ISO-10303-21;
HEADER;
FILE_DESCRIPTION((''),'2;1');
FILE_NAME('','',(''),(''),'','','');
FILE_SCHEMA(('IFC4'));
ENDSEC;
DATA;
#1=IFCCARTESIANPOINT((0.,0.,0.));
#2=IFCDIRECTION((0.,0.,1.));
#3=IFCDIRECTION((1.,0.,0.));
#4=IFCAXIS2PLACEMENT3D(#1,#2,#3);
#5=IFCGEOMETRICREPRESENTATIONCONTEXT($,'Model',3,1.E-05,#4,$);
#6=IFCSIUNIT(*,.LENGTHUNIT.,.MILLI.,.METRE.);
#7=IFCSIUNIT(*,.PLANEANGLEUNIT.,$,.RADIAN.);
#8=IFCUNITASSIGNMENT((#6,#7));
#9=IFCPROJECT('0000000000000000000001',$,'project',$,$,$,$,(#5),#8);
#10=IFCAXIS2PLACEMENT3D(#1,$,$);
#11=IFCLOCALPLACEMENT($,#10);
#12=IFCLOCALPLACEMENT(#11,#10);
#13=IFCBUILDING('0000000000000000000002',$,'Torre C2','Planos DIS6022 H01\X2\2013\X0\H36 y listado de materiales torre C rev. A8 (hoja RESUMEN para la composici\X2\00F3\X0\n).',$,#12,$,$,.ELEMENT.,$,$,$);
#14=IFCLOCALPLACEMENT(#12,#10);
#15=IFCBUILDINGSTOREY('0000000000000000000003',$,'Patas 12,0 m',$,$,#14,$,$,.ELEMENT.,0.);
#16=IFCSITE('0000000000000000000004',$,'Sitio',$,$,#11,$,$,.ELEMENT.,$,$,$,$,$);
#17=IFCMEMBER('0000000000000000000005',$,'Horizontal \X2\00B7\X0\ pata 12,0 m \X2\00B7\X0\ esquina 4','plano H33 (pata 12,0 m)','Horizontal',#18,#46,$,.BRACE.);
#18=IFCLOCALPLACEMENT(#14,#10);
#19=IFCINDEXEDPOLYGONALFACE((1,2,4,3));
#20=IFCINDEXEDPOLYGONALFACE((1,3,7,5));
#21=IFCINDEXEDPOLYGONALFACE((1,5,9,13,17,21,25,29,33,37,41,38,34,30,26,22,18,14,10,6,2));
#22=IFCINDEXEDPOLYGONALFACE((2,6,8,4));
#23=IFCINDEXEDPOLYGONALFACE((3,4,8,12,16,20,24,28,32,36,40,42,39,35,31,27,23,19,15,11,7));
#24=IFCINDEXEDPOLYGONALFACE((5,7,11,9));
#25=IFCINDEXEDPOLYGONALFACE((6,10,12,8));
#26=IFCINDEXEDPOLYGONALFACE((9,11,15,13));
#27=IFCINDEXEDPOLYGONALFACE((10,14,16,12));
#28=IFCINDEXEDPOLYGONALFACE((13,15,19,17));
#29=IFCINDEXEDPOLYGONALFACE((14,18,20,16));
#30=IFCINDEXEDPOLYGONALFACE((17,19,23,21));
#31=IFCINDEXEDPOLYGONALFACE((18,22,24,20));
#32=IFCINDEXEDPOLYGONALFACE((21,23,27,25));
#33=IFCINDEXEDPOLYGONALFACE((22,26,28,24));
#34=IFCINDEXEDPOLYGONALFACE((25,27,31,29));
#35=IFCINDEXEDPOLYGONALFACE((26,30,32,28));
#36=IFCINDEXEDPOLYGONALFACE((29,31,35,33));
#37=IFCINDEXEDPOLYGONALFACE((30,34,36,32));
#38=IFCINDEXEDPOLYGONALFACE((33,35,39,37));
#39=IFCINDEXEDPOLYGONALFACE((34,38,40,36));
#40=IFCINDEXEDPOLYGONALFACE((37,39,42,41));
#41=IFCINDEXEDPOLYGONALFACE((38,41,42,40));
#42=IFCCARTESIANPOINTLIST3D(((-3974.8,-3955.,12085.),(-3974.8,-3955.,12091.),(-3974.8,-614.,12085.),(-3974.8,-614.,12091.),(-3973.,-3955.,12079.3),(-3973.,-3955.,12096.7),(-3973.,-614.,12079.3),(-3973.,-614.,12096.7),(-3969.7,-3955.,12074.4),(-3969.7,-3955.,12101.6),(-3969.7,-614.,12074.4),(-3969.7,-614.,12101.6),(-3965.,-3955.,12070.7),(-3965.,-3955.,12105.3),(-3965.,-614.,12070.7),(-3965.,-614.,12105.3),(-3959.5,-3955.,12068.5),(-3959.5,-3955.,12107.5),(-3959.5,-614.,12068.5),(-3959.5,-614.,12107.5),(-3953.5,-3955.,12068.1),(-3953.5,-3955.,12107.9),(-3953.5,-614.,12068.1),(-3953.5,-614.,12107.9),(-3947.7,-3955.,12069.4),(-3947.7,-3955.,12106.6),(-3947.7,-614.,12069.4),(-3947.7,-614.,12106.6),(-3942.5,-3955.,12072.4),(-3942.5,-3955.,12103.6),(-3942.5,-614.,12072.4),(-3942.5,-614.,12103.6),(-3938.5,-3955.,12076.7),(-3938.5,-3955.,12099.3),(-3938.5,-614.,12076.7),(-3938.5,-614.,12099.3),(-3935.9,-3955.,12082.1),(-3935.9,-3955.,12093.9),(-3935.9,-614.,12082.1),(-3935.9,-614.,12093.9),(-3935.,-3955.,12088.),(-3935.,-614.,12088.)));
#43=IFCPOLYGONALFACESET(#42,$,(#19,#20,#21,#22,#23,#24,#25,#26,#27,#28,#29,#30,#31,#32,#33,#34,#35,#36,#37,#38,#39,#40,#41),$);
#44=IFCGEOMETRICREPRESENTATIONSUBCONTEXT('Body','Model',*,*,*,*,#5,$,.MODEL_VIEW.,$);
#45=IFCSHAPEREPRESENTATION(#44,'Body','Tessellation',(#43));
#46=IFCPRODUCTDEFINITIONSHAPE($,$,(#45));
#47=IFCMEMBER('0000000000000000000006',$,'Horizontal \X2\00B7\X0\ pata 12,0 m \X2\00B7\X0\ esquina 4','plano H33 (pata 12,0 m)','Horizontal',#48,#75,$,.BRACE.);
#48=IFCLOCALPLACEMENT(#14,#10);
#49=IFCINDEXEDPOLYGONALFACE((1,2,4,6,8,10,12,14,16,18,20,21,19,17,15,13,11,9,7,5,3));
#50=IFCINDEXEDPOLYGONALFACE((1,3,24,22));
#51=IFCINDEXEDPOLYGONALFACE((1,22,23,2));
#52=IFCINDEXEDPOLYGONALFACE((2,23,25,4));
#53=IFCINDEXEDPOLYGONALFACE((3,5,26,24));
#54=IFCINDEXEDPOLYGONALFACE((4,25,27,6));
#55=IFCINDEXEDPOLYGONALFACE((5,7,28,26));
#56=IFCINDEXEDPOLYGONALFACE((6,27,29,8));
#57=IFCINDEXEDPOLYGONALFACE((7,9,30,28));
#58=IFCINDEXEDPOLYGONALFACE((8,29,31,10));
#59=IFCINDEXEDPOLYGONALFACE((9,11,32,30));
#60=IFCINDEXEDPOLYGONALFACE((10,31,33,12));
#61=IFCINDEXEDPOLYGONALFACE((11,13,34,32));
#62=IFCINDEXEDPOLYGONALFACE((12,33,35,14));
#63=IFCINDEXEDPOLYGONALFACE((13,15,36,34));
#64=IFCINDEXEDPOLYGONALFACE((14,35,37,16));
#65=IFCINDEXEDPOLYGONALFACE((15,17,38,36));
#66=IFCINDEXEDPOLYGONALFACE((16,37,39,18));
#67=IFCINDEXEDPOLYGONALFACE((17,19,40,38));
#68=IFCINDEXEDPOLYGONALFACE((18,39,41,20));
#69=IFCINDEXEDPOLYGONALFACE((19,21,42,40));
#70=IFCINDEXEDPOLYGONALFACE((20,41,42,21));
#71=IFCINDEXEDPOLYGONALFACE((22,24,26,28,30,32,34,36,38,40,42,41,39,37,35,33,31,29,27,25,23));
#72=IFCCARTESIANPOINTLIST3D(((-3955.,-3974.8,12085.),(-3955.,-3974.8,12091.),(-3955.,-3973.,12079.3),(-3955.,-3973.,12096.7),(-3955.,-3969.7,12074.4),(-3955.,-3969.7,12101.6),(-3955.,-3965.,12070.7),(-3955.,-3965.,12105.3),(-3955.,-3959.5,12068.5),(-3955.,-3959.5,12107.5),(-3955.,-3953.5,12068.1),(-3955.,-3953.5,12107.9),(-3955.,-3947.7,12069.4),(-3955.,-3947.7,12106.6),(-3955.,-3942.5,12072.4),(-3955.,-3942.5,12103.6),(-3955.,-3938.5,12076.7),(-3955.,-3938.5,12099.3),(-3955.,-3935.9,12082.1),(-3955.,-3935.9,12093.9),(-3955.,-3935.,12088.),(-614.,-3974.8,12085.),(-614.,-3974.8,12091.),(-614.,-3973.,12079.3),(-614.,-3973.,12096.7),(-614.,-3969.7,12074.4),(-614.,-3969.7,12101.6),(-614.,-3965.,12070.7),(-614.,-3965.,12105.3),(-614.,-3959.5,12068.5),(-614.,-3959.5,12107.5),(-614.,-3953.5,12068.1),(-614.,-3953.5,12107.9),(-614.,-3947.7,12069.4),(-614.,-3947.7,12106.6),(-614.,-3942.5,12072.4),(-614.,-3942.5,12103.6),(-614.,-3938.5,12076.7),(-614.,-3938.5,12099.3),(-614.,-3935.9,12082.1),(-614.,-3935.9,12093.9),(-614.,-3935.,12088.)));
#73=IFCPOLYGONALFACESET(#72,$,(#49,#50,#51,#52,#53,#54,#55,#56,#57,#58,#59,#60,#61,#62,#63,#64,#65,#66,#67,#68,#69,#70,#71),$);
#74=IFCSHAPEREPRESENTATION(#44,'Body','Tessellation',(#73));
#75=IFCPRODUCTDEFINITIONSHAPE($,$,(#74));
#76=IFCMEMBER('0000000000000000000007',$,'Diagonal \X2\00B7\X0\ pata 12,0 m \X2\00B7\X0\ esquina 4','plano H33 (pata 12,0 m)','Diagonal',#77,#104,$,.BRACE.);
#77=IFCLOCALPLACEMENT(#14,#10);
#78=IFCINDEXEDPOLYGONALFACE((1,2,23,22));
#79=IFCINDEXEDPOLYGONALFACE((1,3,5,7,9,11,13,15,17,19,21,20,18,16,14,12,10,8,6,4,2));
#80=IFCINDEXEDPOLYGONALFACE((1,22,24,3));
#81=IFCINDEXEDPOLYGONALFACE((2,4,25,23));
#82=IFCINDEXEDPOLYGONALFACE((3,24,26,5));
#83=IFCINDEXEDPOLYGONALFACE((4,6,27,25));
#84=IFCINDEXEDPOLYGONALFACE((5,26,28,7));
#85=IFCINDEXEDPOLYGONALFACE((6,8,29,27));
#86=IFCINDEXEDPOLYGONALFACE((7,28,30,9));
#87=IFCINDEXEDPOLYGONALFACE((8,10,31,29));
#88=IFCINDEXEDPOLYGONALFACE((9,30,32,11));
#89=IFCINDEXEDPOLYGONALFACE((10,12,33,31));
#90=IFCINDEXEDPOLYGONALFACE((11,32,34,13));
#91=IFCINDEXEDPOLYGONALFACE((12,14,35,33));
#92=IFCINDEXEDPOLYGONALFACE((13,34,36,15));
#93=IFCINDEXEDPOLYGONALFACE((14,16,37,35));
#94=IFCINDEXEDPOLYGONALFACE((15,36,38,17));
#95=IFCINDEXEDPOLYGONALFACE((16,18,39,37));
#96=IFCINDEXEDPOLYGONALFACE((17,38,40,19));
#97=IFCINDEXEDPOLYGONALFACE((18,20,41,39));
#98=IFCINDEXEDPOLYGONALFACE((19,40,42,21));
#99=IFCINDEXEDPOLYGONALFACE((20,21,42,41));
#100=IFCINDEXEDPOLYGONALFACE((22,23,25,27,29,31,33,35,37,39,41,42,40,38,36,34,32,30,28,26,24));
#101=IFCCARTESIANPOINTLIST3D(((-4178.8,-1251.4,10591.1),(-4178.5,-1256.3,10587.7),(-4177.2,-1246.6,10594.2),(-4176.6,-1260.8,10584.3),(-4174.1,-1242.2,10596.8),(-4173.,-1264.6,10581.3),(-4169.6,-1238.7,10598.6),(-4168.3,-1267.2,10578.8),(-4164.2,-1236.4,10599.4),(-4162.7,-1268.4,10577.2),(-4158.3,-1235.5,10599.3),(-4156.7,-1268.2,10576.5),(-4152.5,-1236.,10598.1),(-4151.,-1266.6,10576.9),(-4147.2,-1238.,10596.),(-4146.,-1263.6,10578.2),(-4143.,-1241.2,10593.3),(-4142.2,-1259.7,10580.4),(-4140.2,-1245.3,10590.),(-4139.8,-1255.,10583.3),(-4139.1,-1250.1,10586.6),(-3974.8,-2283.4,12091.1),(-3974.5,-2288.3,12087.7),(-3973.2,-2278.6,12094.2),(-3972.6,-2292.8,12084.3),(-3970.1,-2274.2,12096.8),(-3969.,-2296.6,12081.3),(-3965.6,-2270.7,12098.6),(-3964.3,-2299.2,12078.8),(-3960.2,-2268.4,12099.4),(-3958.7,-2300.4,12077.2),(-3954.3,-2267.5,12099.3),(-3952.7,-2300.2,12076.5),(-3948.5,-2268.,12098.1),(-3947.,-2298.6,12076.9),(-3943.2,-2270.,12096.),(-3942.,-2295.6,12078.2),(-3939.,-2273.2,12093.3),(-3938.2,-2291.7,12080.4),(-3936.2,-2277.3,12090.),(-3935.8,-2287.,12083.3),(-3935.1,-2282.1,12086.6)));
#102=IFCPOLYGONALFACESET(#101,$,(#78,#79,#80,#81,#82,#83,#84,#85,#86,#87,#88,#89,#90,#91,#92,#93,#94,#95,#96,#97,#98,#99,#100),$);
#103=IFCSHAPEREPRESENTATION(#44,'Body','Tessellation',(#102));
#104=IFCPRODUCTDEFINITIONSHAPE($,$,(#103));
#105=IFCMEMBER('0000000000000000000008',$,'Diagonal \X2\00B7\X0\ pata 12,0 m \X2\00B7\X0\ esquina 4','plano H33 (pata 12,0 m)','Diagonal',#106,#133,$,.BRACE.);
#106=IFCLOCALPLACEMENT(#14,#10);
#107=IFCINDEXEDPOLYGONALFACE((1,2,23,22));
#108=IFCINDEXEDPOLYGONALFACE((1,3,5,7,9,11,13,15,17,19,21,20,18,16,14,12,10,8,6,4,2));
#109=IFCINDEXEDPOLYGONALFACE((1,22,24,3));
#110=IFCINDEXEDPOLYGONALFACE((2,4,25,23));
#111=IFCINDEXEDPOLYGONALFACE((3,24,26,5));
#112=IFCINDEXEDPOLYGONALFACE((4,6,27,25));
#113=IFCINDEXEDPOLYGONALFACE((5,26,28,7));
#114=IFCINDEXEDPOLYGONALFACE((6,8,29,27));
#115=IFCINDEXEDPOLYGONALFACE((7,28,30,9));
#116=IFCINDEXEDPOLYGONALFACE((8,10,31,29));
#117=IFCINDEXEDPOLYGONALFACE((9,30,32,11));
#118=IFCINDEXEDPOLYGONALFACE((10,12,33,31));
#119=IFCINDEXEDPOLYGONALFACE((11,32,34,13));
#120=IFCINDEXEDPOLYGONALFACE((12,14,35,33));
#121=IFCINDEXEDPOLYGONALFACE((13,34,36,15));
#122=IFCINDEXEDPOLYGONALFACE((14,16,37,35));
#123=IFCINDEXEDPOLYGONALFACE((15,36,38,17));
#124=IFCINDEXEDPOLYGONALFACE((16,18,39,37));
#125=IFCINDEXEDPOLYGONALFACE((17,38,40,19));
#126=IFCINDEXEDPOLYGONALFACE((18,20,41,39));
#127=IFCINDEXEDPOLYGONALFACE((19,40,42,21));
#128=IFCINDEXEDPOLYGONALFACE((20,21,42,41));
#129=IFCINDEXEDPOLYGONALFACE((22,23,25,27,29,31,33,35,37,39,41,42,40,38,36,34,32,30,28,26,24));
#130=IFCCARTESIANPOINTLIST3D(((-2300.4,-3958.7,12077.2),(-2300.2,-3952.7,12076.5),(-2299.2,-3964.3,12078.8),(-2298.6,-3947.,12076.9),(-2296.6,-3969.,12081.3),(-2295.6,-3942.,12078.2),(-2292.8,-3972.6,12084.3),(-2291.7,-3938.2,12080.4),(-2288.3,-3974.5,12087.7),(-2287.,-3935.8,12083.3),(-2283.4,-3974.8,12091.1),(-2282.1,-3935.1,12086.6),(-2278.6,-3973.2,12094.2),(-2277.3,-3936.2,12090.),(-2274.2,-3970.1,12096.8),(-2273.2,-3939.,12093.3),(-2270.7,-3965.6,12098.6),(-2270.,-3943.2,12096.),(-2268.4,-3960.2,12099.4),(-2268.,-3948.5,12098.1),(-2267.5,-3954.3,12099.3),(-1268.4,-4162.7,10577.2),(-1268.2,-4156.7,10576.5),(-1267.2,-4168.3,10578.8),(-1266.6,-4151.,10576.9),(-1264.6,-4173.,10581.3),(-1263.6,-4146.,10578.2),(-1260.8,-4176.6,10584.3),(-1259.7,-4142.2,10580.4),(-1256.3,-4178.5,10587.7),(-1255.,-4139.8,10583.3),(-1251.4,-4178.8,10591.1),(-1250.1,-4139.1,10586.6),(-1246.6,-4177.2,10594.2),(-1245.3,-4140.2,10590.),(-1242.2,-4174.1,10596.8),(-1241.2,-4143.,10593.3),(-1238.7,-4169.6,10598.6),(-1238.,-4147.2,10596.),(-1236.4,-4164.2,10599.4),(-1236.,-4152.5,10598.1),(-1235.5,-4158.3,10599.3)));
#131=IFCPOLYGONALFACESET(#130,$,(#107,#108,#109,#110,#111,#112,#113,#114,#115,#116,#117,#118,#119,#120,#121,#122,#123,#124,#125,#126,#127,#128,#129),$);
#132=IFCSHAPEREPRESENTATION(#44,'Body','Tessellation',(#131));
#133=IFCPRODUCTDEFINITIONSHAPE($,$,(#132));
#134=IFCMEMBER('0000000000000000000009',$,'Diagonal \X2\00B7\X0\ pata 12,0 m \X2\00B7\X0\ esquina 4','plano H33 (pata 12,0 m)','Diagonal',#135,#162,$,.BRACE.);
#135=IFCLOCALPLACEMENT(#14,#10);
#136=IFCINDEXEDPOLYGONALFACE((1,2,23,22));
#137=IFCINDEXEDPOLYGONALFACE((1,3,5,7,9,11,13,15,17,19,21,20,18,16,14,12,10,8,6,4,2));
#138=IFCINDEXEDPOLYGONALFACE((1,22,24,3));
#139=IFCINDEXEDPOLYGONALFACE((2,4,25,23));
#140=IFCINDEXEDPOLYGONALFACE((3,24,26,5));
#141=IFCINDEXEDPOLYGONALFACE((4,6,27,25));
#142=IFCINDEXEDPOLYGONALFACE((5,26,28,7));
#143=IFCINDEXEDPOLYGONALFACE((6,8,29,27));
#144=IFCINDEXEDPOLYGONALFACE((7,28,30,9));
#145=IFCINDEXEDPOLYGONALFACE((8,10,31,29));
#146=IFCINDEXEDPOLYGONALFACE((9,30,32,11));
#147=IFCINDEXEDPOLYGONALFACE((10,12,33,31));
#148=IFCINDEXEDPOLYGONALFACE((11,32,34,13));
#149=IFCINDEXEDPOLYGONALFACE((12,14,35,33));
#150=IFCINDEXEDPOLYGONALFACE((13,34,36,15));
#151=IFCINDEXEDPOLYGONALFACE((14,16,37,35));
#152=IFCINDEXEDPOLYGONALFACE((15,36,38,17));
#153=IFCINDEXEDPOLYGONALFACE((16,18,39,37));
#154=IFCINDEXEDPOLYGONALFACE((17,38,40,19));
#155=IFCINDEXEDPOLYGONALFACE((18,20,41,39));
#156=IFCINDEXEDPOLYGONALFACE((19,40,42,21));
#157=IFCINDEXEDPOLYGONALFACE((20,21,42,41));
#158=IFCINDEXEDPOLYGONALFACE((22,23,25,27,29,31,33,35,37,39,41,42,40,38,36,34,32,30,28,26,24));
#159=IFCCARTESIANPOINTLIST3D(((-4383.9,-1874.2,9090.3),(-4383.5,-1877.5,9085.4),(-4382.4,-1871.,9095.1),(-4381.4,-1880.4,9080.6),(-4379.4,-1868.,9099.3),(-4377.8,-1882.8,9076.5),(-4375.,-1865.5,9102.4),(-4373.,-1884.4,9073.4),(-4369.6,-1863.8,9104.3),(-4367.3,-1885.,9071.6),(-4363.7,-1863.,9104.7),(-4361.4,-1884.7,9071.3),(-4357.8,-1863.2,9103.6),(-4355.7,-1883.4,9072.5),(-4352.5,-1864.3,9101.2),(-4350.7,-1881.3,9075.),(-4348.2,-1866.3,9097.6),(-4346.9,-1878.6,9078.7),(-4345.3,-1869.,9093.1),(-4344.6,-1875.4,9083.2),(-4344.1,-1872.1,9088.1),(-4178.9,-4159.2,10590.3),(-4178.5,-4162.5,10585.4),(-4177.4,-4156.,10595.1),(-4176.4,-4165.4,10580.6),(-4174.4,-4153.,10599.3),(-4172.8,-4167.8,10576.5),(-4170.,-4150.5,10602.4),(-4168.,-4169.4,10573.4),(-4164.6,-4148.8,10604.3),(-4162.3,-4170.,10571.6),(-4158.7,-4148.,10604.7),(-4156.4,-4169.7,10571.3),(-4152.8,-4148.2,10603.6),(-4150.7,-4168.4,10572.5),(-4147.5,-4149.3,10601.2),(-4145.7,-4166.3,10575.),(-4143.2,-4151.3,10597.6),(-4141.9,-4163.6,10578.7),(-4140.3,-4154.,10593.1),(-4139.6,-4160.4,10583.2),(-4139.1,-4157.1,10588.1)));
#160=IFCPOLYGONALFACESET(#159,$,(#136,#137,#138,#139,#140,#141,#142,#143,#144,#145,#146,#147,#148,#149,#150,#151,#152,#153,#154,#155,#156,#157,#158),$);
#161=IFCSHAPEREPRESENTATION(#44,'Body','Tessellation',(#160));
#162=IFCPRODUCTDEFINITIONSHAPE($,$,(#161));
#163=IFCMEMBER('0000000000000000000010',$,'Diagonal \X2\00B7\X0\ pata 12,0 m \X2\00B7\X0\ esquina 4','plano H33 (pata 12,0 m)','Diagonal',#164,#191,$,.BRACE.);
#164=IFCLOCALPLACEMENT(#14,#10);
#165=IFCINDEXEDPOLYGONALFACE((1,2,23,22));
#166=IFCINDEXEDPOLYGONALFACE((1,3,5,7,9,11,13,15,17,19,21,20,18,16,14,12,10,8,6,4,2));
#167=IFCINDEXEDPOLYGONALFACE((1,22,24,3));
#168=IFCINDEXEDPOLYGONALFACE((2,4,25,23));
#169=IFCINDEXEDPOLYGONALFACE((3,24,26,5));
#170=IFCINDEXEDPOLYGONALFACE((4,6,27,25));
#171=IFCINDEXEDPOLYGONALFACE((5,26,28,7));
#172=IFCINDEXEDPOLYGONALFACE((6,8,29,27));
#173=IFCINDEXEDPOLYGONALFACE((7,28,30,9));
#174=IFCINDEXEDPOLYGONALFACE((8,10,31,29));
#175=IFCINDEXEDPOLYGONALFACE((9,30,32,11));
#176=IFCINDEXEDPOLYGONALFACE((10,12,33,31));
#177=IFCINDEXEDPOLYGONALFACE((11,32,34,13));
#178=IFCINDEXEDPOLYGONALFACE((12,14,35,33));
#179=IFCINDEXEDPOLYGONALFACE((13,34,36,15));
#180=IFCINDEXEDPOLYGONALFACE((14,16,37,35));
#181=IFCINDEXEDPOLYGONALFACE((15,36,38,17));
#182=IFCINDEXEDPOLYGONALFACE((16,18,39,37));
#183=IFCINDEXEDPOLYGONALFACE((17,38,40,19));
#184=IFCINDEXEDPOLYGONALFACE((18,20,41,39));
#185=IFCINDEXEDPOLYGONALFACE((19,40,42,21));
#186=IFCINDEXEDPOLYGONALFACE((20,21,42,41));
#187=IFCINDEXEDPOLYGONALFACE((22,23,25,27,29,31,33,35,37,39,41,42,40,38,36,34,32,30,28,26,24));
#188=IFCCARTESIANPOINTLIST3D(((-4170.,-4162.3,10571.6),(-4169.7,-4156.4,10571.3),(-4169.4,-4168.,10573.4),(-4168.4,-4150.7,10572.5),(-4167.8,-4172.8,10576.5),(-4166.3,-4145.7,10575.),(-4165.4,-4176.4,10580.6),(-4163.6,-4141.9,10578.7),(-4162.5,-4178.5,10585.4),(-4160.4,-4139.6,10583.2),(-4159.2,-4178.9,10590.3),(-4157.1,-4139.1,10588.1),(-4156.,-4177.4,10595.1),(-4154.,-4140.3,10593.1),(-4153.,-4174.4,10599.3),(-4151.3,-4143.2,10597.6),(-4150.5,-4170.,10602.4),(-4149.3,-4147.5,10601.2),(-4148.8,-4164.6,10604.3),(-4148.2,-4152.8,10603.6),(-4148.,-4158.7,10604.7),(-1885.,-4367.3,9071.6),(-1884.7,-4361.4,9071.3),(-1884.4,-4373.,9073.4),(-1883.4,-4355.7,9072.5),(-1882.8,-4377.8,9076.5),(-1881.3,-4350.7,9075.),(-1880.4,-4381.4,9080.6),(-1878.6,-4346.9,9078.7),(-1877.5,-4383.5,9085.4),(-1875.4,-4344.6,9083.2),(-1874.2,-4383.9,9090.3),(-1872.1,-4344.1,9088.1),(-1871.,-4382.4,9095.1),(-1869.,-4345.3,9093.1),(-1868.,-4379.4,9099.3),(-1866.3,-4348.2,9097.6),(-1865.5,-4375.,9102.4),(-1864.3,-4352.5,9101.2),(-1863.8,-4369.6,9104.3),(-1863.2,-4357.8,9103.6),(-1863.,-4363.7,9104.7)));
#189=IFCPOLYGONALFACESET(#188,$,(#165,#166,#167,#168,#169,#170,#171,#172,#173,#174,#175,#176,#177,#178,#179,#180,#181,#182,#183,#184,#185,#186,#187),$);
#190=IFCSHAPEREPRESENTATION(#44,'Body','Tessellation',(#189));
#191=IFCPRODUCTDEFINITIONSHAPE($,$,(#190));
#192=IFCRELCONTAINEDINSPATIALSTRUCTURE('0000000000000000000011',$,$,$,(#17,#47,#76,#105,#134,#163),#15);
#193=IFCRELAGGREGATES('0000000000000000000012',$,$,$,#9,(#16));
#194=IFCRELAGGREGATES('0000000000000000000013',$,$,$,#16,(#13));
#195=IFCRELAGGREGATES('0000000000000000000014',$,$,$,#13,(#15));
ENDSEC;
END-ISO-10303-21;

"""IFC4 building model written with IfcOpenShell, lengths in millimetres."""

from ifc_helpers import new_model, si_unit, frame, origin, origin_with_axes, place, context, subcontext, project, spatial, circle, extrude, element, save


model = new_model("IFC4")

# Units and contexts
model_context = context("Model", 3, precision=1e-05, world=origin_with_axes())
body_context = subcontext(model_context, "Body", "Model", "MODEL_VIEW")
ifc_project = project(units=[si_unit("LENGTHUNIT", "METRE", prefix="MILLI"), si_unit("PLANEANGLEUNIT", "RADIAN")], contexts=[model_context])

# Site, building, storey
site_placement = place(None, origin())
site = spatial("IfcSite", under=ifc_project, at=site_placement, Name="Sitio", CompositionType="ELEMENT")
building_placement = place(site_placement, origin())
building = spatial("IfcBuilding", under=site, at=building_placement, Name="Torre C2", Description="Planos DIS6022 H01–H36 y listado de materiales torre C rev. A8 (hoja RESUMEN para la composición).", CompositionType="ELEMENT")
storey_placement = place(building_placement, origin())
storey = spatial("IfcBuildingStorey", under=building, at=storey_placement, Name="Patas 12,0 m", CompositionType="ELEMENT", Elevation=0.0)

# Members
for number, where, z_axis, x_axis, name in (
    (1, (-3955.0, -3955.0, 12088.0), (0.0, 1.0, 0.0), (1.0, 0.0, 0.0), "Horizontal · pata 12,0 m · esquina 4"),
    (2, (-3955.0, -3955.0, 12088.0), (1.0, 0.0, 0.0), (0.0, 1.0, 0.0), "Horizontal · pata 12,0 m · esquina 4"),
):
    element("IfcMember", number, at=place(storey_placement, frame(where, z_axis=z_axis, x_axis=x_axis)), inside=storey, Name=name, Description="plano H33 (pata 12,0 m)", ObjectType="Horizontal", PredefinedType="BRACE", context=body_context, shape_type="SweptSolid", body=[
        extrude(circle(Radius=20.0), None, (0.0, 0.0, 1.0), 3341.0),
    ])
for number, where, z_axis, x_axis, name in (
    (3, (-3955.0, -2284.0, 12088.0), (-0.111347, 0.563284, -0.818727), (0.937537, 0.332767, 0.101439), "Diagonal · pata 12,0 m · esquina 4"),
    (4, (-2284.0, -3955.0, 12088.0), (0.563284, -0.111347, -0.818727), (0.332767, 0.937537, 0.101439), "Diagonal · pata 12,0 m · esquina 4"),
):
    element("IfcMember", number, at=place(storey_placement, frame(where, z_axis=z_axis, x_axis=x_axis)), inside=storey, Name=name, Description="plano H33 (pata 12,0 m)", ObjectType="Diagonal", PredefinedType="BRACE", context=body_context, shape_type="SweptSolid", body=[
        extrude(circle(Radius=20.0), None, (0.0, 0.0, 1.0), 1832.1),
    ])
for number, where, z_axis, x_axis, name in (
    (5, (-4159.0, -4159.0, 10588.0), (-0.074789, 0.833628, -0.547239), (0.934323, 0.250361, 0.253692), "Diagonal · pata 12,0 m · esquina 4"),
    (6, (-4159.0, -4159.0, 10588.0), (0.833628, -0.074789, -0.547239), (0.250361, 0.934323, 0.253692), "Diagonal · pata 12,0 m · esquina 4"),
):
    element("IfcMember", number, at=place(storey_placement, frame(where, z_axis=z_axis, x_axis=x_axis)), inside=storey, Name=name, Description="plano H33 (pata 12,0 m)", ObjectType="Diagonal", PredefinedType="BRACE", context=body_context, shape_type="SweptSolid", body=[
        extrude(circle(Radius=20.0), None, (0.0, 0.0, 1.0), 2741.0),
    ])

save(model, "model.ifc")
